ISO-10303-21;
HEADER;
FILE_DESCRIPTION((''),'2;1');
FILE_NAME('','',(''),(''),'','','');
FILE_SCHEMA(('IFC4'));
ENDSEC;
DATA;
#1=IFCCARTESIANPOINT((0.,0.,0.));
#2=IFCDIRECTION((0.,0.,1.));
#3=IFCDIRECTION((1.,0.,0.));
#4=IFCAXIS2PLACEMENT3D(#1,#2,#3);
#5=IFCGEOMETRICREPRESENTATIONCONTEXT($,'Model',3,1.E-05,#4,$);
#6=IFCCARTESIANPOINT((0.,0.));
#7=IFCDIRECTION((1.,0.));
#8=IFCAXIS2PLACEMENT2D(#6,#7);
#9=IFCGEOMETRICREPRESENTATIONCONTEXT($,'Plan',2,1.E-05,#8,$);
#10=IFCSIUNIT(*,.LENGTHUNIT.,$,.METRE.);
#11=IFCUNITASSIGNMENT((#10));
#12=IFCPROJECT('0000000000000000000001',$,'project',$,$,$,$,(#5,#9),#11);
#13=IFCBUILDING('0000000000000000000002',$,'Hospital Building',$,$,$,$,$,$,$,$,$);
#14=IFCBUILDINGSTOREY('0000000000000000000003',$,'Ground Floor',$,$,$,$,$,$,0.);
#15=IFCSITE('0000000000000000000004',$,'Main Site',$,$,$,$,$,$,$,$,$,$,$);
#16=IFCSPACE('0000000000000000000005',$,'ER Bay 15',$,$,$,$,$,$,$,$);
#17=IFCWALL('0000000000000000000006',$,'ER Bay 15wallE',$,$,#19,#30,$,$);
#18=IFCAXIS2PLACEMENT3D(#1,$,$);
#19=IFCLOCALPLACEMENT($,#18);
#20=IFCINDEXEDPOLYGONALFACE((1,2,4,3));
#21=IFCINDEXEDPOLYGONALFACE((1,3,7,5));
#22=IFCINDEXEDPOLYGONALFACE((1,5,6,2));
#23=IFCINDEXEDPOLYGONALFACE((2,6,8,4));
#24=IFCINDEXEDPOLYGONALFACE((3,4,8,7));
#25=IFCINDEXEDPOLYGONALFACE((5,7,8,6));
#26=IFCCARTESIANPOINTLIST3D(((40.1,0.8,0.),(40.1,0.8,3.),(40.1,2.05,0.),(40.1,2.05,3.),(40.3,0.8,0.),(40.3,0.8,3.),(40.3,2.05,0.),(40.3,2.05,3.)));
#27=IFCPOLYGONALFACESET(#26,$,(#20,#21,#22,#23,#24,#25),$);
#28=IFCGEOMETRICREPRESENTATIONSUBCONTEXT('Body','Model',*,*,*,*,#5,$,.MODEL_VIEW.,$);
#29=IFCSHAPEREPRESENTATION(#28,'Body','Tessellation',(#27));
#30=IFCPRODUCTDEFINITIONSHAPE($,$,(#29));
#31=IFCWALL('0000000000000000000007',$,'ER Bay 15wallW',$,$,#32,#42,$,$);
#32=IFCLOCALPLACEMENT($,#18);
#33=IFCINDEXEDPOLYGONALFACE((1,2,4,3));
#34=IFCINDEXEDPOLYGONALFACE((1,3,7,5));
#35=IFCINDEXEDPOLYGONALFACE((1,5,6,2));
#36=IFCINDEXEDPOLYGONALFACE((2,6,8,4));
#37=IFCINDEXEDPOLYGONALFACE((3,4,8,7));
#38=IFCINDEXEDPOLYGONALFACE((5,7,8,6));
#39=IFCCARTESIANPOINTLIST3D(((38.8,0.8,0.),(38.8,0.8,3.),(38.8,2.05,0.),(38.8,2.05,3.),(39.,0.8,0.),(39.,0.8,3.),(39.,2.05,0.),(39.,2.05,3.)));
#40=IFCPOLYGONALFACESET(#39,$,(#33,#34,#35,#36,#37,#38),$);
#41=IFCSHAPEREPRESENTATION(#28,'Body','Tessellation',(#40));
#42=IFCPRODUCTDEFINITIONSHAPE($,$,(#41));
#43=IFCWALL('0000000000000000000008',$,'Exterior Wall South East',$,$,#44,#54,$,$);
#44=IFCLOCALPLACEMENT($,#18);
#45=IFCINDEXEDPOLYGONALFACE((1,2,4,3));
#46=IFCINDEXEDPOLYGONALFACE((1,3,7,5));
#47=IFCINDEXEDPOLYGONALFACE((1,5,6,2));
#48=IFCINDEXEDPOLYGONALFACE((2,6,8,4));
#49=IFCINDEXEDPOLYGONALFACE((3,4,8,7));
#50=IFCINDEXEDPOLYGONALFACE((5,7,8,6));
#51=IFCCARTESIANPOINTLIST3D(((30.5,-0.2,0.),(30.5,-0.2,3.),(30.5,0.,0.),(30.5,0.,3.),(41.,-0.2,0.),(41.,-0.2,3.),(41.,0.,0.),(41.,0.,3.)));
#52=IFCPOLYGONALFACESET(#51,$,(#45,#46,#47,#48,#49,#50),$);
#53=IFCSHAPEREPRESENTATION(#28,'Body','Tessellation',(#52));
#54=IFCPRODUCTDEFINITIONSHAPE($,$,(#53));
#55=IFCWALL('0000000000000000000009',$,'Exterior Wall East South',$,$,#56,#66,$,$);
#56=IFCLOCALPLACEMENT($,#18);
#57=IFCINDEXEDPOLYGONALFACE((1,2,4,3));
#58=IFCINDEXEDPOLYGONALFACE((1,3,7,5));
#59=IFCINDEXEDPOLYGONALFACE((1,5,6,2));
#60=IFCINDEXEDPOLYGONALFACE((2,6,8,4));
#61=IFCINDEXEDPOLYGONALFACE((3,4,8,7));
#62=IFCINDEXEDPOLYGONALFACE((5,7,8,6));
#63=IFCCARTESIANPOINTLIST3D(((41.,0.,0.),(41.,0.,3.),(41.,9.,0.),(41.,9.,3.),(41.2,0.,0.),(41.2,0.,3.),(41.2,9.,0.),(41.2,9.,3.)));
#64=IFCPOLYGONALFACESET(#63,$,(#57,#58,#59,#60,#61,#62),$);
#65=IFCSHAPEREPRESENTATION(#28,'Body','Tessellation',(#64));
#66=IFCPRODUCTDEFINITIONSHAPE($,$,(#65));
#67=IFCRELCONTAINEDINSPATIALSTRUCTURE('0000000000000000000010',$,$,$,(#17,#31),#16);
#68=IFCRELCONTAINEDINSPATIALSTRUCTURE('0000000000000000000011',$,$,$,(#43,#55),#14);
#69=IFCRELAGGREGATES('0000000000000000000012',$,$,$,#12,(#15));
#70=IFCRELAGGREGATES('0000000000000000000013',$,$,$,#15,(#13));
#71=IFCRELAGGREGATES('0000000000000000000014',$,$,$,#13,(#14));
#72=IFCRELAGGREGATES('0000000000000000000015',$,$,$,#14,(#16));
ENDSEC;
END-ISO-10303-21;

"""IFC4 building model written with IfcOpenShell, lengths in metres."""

from ifc_helpers import new_model, si_unit, frame, origin_with_axes, origin_2d_with_axis, place, context, subcontext, project, spatial, indexed_curve, outline, extrude, element, save


model = new_model("IFC4")

# Units and contexts
model_context = context("Model", 3, precision=1e-05, world=origin_with_axes())
plan_context = context("Plan", 2, precision=1e-05, world=origin_2d_with_axis())
body_context = subcontext(model_context, "Body", "Model", "MODEL_VIEW")
ifc_project = project(units=[si_unit("LENGTHUNIT", "METRE")], contexts=[model_context, plan_context])

# Site, building, storey
site = spatial("IfcSite", under=ifc_project, Name="Main Site")
building = spatial("IfcBuilding", under=site, Name="Hospital Building")
storey = spatial("IfcBuildingStorey", under=building, Name="Ground Floor", Elevation=0.0)

# Shared definitions
space_1 = spatial("IfcSpace", under=storey, Name="ER Bay 15")

# Walls
for number, where, z_axis, x_axis, name in (
    (1, (40.3, 0.8, 0.0), (0.0, 0.0, 1.0), (0.0, 1.0, 0.0), "ER Bay 15wallE"),
    (2, (39.0, 0.8, 0.0), (0.0, 0.0, 1.0), (0.0, 1.0, 0.0), "ER Bay 15wallW"),
):
    element("IfcWall", number, at=place(None, frame(where, z_axis=z_axis, x_axis=x_axis)), inside=space_1, Name=name, context=body_context, shape_type="SweptSolid", body=[
        extrude(outline(indexed_curve([(0.0, 0.0), (0.0, 0.2), (1.25, 0.2), (1.25, 0.0), (0.0, 0.0)], self_intersect=False)), origin_with_axes(), (0.0, 0.0, 1.0), 3.0),
    ])
wall_1_placement = place(None, frame((30.5, -0.2, 0.0), z_axis=(0.0, 0.0, 1.0), x_axis=(1.0, 0.0, 0.0)))
element("IfcWall", 3, at=wall_1_placement, inside=storey, Name="Exterior Wall South East", context=body_context, shape_type="SweptSolid", body=[
    extrude(outline(indexed_curve([(0.0, 0.0), (0.0, 0.2), (10.5, 0.2), (10.5, 0.0), (0.0, 0.0)], self_intersect=False)), origin_with_axes(), (0.0, 0.0, 1.0), 3.0),
])
wall_2_placement = place(None, frame((41.2, 0.0, 0.0), z_axis=(0.0, 0.0, 1.0), x_axis=(0.0, 1.0, 0.0)))
element("IfcWall", 4, at=wall_2_placement, inside=storey, Name="Exterior Wall East South", context=body_context, shape_type="SweptSolid", body=[
    extrude(outline(indexed_curve([(0.0, 0.0), (0.0, 0.2), (9.0, 0.2), (9.0, 0.0), (0.0, 0.0)], self_intersect=False)), origin_with_axes(), (0.0, 0.0, 1.0), 3.0),
])

save(model, "model.ifc")
